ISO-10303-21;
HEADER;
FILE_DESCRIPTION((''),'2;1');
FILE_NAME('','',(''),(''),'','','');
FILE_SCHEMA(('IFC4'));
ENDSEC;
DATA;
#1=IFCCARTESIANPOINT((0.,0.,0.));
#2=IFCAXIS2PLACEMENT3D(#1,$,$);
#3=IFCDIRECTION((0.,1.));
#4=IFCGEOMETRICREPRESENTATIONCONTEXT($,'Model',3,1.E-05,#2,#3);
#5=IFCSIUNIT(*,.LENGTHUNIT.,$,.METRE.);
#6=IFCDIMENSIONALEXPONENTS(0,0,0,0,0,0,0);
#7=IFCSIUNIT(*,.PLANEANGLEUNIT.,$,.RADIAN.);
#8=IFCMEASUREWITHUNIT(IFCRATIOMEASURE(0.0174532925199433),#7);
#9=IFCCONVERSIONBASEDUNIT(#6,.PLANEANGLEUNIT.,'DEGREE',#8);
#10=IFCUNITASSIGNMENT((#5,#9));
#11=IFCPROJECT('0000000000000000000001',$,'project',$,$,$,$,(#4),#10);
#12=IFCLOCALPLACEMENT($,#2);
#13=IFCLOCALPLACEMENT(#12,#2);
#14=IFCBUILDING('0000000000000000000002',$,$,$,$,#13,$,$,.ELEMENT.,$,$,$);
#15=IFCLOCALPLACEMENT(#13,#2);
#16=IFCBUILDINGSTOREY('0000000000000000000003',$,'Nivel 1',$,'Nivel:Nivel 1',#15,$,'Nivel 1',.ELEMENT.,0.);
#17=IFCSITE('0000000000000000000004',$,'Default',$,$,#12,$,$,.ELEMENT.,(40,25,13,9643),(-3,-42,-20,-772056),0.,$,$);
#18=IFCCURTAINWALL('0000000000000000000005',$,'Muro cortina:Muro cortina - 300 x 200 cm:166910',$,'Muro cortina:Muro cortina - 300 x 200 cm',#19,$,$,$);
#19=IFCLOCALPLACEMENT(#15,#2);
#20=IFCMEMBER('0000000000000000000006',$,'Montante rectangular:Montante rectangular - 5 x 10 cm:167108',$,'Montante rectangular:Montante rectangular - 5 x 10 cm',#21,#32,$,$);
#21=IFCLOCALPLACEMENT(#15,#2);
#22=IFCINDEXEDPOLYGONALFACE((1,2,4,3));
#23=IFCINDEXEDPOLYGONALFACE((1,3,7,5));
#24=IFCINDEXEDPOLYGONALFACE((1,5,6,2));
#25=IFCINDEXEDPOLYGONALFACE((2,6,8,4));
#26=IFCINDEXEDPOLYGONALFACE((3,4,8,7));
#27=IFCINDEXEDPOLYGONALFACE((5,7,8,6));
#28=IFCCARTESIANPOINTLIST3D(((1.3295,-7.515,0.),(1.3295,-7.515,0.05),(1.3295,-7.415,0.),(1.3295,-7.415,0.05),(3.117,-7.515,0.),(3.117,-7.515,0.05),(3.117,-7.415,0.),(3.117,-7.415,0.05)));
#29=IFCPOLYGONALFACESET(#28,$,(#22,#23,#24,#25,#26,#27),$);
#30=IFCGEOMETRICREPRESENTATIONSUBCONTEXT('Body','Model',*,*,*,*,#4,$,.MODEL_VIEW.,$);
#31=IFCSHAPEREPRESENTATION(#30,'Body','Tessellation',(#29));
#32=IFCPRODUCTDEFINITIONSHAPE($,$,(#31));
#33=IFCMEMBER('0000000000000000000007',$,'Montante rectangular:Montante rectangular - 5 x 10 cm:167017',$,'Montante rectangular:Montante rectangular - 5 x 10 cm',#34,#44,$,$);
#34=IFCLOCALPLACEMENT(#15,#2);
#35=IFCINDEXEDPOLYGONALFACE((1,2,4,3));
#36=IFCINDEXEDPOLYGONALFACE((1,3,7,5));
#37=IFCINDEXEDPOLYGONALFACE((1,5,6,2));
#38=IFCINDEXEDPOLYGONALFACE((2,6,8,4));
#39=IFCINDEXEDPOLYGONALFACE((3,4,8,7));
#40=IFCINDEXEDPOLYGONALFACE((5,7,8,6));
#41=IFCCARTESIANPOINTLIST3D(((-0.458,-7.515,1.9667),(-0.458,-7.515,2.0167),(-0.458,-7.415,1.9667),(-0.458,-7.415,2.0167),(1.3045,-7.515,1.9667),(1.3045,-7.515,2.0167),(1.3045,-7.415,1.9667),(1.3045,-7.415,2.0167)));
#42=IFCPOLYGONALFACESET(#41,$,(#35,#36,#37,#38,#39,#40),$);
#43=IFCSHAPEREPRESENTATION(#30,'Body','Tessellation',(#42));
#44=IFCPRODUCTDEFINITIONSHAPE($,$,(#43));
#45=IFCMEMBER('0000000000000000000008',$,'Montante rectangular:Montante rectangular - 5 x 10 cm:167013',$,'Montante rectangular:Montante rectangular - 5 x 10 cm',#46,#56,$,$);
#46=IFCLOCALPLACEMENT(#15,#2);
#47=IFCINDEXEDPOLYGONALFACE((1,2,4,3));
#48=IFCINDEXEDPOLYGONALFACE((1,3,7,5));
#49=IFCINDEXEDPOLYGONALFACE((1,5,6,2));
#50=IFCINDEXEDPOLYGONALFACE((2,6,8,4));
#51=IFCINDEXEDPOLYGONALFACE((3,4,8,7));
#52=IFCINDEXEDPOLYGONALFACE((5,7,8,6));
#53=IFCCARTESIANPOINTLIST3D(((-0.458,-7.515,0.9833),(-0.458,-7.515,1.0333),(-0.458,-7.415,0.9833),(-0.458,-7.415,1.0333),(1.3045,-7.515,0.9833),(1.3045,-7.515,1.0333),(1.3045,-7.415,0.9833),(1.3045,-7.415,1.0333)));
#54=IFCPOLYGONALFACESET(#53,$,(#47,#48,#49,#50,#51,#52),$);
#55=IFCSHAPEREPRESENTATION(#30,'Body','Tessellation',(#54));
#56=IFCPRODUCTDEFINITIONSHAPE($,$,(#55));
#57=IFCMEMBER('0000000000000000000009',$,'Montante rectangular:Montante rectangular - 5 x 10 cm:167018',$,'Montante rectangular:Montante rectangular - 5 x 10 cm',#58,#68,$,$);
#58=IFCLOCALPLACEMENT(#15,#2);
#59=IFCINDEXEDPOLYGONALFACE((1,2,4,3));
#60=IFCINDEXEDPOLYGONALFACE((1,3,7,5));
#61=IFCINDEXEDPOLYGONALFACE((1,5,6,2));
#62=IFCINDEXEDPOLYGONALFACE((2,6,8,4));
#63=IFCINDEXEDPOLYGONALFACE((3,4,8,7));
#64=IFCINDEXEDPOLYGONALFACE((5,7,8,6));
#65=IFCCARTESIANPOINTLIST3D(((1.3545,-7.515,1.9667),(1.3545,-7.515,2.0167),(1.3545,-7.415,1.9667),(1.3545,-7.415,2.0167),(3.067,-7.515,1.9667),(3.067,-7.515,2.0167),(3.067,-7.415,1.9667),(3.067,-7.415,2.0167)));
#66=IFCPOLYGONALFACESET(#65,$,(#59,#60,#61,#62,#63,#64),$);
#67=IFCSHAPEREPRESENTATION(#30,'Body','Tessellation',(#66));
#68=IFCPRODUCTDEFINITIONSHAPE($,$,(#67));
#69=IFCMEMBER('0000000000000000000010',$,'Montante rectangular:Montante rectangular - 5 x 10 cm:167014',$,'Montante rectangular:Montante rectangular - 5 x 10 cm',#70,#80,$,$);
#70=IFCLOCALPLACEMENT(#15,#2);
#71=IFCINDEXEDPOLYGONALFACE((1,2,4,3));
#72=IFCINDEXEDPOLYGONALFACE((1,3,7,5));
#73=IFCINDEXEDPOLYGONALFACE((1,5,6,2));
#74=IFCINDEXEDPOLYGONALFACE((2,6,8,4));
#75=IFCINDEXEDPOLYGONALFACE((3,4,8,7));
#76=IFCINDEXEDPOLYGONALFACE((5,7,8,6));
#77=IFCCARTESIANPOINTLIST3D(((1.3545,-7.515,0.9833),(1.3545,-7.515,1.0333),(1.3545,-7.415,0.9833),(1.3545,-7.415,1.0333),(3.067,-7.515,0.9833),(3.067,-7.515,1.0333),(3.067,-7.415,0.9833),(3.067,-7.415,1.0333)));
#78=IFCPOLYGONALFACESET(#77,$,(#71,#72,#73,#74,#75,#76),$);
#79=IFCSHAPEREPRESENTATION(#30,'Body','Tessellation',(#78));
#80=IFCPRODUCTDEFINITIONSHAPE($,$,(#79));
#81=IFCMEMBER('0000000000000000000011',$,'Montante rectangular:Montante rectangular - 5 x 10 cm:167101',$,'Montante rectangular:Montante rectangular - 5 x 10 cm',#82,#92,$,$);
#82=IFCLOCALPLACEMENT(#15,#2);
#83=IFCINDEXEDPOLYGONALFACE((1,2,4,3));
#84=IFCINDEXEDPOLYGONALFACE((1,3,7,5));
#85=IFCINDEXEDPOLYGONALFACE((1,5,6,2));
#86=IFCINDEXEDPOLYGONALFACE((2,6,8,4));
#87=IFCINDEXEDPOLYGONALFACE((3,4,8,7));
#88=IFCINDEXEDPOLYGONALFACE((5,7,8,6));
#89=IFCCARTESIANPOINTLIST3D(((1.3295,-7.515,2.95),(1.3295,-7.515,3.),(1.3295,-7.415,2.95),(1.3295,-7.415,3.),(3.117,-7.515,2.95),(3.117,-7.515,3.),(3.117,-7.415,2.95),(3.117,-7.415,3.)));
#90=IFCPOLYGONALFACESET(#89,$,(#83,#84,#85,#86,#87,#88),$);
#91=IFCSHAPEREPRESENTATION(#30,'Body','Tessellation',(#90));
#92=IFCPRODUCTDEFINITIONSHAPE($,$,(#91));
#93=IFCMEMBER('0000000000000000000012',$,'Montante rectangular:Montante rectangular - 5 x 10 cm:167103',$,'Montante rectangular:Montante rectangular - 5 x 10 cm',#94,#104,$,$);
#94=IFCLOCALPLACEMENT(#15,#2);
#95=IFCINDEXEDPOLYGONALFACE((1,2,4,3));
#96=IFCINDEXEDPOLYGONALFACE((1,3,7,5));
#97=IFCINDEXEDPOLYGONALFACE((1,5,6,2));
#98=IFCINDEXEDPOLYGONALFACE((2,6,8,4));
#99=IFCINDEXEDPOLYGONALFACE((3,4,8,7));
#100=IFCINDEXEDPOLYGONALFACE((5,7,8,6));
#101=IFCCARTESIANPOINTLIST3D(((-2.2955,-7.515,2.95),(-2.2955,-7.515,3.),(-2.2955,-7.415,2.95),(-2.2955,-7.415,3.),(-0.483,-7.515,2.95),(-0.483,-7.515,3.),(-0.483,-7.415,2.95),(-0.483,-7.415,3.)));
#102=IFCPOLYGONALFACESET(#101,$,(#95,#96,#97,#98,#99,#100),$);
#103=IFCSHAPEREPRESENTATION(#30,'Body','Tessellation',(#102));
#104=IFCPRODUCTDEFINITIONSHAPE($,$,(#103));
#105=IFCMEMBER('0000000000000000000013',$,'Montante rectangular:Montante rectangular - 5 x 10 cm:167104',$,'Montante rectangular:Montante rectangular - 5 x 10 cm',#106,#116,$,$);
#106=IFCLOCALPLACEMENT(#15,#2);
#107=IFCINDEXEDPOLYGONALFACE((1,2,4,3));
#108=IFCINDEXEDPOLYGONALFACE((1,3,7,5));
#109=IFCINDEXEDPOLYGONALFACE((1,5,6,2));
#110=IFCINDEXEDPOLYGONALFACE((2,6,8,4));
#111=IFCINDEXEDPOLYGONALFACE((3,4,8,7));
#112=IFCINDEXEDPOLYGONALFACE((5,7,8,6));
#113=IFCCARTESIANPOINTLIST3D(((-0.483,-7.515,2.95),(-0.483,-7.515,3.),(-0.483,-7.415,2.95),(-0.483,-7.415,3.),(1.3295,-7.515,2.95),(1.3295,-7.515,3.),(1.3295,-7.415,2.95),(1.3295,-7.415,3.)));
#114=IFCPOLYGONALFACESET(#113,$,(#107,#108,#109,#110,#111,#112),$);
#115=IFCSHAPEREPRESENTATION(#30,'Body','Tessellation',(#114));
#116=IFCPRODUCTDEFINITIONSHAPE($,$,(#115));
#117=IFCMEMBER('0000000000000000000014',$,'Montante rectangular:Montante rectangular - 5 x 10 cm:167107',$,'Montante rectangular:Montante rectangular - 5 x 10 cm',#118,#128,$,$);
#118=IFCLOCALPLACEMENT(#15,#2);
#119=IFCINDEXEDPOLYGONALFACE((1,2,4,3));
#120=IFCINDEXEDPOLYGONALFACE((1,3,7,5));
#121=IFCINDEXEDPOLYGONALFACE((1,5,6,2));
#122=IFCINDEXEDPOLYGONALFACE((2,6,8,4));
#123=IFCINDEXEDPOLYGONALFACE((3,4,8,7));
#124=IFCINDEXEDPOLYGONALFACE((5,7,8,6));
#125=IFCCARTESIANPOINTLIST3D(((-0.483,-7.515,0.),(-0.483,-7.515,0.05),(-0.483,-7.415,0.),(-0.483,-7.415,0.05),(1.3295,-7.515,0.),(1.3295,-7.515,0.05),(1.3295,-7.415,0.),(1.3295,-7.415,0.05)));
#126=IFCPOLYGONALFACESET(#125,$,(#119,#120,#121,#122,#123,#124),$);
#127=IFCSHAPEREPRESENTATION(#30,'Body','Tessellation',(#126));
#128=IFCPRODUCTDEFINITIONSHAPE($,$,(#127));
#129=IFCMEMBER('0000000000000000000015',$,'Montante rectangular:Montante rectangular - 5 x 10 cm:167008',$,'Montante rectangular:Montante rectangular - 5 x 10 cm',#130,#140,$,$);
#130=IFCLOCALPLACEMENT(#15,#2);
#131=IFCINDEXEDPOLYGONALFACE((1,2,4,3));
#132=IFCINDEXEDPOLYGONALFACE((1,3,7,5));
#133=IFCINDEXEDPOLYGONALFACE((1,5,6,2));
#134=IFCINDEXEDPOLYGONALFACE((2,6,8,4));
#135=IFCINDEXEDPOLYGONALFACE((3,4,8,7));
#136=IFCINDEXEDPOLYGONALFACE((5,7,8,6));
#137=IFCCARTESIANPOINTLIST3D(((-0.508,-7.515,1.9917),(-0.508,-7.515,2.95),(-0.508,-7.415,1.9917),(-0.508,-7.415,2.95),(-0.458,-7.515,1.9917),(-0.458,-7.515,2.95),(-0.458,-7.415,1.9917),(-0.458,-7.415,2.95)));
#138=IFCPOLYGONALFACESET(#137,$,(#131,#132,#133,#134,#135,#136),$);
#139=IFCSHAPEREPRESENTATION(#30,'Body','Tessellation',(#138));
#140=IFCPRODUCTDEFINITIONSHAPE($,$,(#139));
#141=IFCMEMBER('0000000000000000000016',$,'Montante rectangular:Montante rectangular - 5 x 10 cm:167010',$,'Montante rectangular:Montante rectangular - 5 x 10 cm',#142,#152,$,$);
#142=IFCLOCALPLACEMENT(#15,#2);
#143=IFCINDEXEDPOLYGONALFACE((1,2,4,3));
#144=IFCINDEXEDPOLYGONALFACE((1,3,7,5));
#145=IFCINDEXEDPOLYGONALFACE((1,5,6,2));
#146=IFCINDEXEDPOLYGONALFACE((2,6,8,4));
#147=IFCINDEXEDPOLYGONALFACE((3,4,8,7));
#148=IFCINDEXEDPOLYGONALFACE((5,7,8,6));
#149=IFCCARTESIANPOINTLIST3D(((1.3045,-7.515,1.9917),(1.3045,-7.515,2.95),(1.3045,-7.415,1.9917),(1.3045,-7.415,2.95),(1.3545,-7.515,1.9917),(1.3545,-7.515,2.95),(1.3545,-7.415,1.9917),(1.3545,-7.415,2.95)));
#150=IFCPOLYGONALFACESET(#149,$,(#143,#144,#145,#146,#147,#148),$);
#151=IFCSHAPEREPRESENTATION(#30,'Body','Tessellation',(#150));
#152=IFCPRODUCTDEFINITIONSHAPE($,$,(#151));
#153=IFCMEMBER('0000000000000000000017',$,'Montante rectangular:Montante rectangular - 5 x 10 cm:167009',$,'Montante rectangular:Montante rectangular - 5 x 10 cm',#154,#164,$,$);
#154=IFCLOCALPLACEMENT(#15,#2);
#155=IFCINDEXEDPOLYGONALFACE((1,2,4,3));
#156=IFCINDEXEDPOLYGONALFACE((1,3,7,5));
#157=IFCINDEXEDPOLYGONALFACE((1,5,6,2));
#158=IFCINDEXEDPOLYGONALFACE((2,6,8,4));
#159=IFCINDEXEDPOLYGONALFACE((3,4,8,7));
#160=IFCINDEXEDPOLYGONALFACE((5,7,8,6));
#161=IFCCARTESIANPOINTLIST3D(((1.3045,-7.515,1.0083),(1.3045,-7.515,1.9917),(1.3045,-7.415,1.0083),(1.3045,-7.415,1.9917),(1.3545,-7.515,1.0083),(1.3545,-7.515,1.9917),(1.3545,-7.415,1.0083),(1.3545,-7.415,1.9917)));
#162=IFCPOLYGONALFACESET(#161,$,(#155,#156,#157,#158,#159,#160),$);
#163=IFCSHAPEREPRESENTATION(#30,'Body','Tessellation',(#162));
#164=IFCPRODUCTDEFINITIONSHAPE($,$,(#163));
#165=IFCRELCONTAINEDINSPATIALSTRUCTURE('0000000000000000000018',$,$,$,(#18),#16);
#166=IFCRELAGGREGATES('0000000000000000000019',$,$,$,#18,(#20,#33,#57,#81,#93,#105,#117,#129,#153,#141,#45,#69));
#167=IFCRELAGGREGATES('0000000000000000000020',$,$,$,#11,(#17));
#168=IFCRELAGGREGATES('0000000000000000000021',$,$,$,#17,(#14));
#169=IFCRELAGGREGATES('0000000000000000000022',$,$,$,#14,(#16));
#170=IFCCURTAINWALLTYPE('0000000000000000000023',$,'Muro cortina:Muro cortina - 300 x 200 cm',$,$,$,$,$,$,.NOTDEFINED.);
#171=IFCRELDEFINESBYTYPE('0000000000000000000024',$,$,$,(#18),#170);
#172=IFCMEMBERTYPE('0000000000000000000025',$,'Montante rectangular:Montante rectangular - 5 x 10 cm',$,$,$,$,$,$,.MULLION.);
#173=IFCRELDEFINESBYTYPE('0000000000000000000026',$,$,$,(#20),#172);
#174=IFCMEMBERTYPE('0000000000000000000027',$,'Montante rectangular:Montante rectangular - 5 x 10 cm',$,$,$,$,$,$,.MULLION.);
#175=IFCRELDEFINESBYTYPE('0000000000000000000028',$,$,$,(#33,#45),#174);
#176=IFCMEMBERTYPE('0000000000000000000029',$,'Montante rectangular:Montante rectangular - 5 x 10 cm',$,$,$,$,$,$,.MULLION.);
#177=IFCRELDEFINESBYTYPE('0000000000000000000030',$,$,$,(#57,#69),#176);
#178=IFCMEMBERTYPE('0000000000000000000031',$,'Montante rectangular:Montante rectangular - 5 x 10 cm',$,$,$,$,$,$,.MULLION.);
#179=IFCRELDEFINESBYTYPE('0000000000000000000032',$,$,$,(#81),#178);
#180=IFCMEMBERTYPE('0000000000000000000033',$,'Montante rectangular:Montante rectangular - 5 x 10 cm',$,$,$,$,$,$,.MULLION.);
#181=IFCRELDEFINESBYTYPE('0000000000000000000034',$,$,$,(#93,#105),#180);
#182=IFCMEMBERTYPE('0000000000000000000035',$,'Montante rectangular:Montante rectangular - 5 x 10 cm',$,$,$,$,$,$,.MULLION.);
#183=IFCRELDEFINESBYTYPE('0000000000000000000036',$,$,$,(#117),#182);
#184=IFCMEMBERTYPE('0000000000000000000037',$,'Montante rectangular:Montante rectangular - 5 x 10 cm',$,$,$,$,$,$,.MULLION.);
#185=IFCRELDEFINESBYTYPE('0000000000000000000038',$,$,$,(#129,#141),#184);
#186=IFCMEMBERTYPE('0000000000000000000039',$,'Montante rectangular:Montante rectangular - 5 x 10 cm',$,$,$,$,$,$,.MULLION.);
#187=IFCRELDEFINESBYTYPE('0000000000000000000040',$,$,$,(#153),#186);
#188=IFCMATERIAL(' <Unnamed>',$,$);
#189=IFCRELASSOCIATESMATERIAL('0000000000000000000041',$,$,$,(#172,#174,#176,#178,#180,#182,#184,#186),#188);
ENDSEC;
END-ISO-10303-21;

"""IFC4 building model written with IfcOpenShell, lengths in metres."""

from ifc_helpers import new_model, entity, si_unit, converted_unit, direction, frame, origin, origin_2d_with_axis, place, context, subcontext, project, spatial, rectangle, extrude, source, transform, mapped, material, type_object, type_shapes, element, aggregate, save


model = new_model("IFC4")

# Units and contexts
model_context = context("Model", 3, precision=1e-05, world=origin(), true_north=direction((0.0, 1.0)))
body_context = subcontext(model_context, "Body", "Model", "MODEL_VIEW")
ifc_project = project(units=[si_unit("LENGTHUNIT", "METRE"), converted_unit("PLANEANGLEUNIT", "DEGREE", entity("IfcRatioMeasure", 0.0174532925199433), si_unit("PLANEANGLEUNIT", "RADIAN"), dimensions=[0, 0, 0, 0, 0, 0, 0])], contexts=[model_context])

# Site, building, storey
site_placement = place(None, origin())
site = spatial("IfcSite", under=ifc_project, at=site_placement, Name="Default", CompositionType="ELEMENT", RefLatitude=(40, 25, 13, 9643), RefLongitude=(-3, -42, -20, -772056), RefElevation=0.0)
building_placement = place(site_placement, origin())
building = spatial("IfcBuilding", under=site, at=building_placement, CompositionType="ELEMENT")
storey_placement = place(building_placement, origin())
storey = spatial("IfcBuildingStorey", under=building, at=storey_placement, Name="Nivel 1", ObjectType="Nivel:Nivel 1", LongName="Nivel 1", CompositionType="ELEMENT", Elevation=0.0)

# Curtain wall, members
curtain_wall_type = type_object("IfcCurtainWallType", Name="Muro cortina:Muro cortina - 300 x 200 cm", PredefinedType="NOTDEFINED")
curtain_wall_placement = place(storey_placement, origin())
curtain_wall = element("IfcCurtainWall", 1, at=curtain_wall_placement, inside=storey, type_object=curtain_wall_type, Name="Muro cortina:Muro cortina - 300 x 200 cm:166910", ObjectType="Muro cortina:Muro cortina - 300 x 200 cm")
ifc_material_1 = material(Name=" <Unnamed>")
member_type_1 = type_object("IfcMemberType", Name="Montante rectangular:Montante rectangular - 5 x 10 cm", PredefinedType="MULLION", material=ifc_material_1)
shared_shape_1 = source(origin(), body_context, "Body", "SweptSolid", [
    extrude(rectangle(XDim=0.1, YDim=0.05, at=origin_2d_with_axis()), frame((-0.025, 0.0, -1.7875), z_axis=(0.0, 0.0, 1.0), x_axis=(0.0, -1.0, 0.0)), (0.0, 0.0, 1.0), 1.7875),
])
type_shapes(member_type_1, [shared_shape_1])
member_1_placement = place(storey_placement, frame((1.3295, -7.465, 0.0), z_axis=(-1.0, 0.0, 0.0), x_axis=(0.0, 0.0, -1.0)))
member_1 = element("IfcMember", 2, at=member_1_placement, type_object=member_type_1, Name="Montante rectangular:Montante rectangular - 5 x 10 cm:167108", ObjectType="Montante rectangular:Montante rectangular - 5 x 10 cm", context=body_context, shape_type="MappedRepresentation", body=[
    mapped(shared_shape_1, transform((0.0, 0.0, 0.0), scale=1.0)),
])
member_type_2 = type_object("IfcMemberType", Name="Montante rectangular:Montante rectangular - 5 x 10 cm", PredefinedType="MULLION", material=ifc_material_1)
shared_shape_2 = source(origin(), body_context, "Body", "SweptSolid", [
    extrude(rectangle(XDim=0.1, YDim=0.05, at=origin_2d_with_axis()), frame((0.0, 0.0, -1.7625), z_axis=(0.0, 0.0, 1.0), x_axis=(0.0, -1.0, 0.0)), (0.0, 0.0, 1.0), 1.7625),
])
type_shapes(member_type_2, [shared_shape_2])
member_2_placement = place(storey_placement, frame((1.3045, -7.465, 1.9917), z_axis=(1.0, 0.0, 0.0), x_axis=(0.0, 0.0, 1.0)))
member_2 = element("IfcMember", 3, at=member_2_placement, type_object=member_type_2, Name="Montante rectangular:Montante rectangular - 5 x 10 cm:167017", ObjectType="Montante rectangular:Montante rectangular - 5 x 10 cm", context=body_context, shape_type="MappedRepresentation", body=[
    mapped(shared_shape_2, transform((0.0, 0.0, 0.0), scale=1.0)),
])
member_3_placement = place(storey_placement, frame((1.3045, -7.465, 1.0083), z_axis=(1.0, 0.0, 0.0), x_axis=(0.0, 0.0, 1.0)))
member_3 = element("IfcMember", 4, at=member_3_placement, type_object=member_type_2, Name="Montante rectangular:Montante rectangular - 5 x 10 cm:167013", ObjectType="Montante rectangular:Montante rectangular - 5 x 10 cm", context=body_context, shape_type="MappedRepresentation", body=[
    mapped(shared_shape_2, transform((0.0, 0.0, 0.0), scale=1.0)),
])
member_type_3 = type_object("IfcMemberType", Name="Montante rectangular:Montante rectangular - 5 x 10 cm", PredefinedType="MULLION", material=ifc_material_1)
shared_shape_3 = source(origin(), body_context, "Body", "SweptSolid", [
    extrude(rectangle(XDim=0.1, YDim=0.05, at=origin_2d_with_axis()), frame((0.0, 0.0, -1.7125), z_axis=(0.0, 0.0, 1.0), x_axis=(0.0, -1.0, 0.0)), (0.0, 0.0, 1.0), 1.7125),
])
type_shapes(member_type_3, [shared_shape_3])
member_4_placement = place(storey_placement, frame((3.067, -7.465, 1.9917), z_axis=(1.0, 0.0, 0.0), x_axis=(0.0, 0.0, 1.0)))
member_4 = element("IfcMember", 5, at=member_4_placement, type_object=member_type_3, Name="Montante rectangular:Montante rectangular - 5 x 10 cm:167018", ObjectType="Montante rectangular:Montante rectangular - 5 x 10 cm", context=body_context, shape_type="MappedRepresentation", body=[
    mapped(shared_shape_3, transform((0.0, 0.0, 0.0), scale=1.0)),
])
member_5_placement = place(storey_placement, frame((3.067, -7.465, 1.0083), z_axis=(1.0, 0.0, 0.0), x_axis=(0.0, 0.0, 1.0)))
member_5 = element("IfcMember", 6, at=member_5_placement, type_object=member_type_3, Name="Montante rectangular:Montante rectangular - 5 x 10 cm:167014", ObjectType="Montante rectangular:Montante rectangular - 5 x 10 cm", context=body_context, shape_type="MappedRepresentation", body=[
    mapped(shared_shape_3, transform((0.0, 0.0, 0.0), scale=1.0)),
])
member_type_4 = type_object("IfcMemberType", Name="Montante rectangular:Montante rectangular - 5 x 10 cm", PredefinedType="MULLION", material=ifc_material_1)
shared_shape_4 = source(origin(), body_context, "Body", "SweptSolid", [
    extrude(rectangle(XDim=0.1, YDim=0.05, at=origin_2d_with_axis()), frame((-0.025, 0.0, -1.7875), z_axis=(0.0, 0.0, 1.0), x_axis=(0.0, -1.0, 0.0)), (0.0, 0.0, 1.0), 1.7875),
])
type_shapes(member_type_4, [shared_shape_4])
member_6_placement = place(storey_placement, frame((3.117, -7.465, 3.0), z_axis=(1.0, 0.0, 0.0), x_axis=(0.0, 0.0, 1.0)))
member_6 = element("IfcMember", 7, at=member_6_placement, type_object=member_type_4, Name="Montante rectangular:Montante rectangular - 5 x 10 cm:167101", ObjectType="Montante rectangular:Montante rectangular - 5 x 10 cm", context=body_context, shape_type="MappedRepresentation", body=[
    mapped(shared_shape_4, transform((0.0, 0.0, 0.0), scale=1.0)),
])
member_type_5 = type_object("IfcMemberType", Name="Montante rectangular:Montante rectangular - 5 x 10 cm", PredefinedType="MULLION", material=ifc_material_1)
shared_shape_5 = source(origin(), body_context, "Body", "SweptSolid", [
    extrude(rectangle(XDim=0.1, YDim=0.05, at=origin_2d_with_axis()), frame((-0.025, 0.0, -1.8125), z_axis=(0.0, 0.0, 1.0), x_axis=(0.0, -1.0, 0.0)), (0.0, 0.0, 1.0), 1.8125),
])
type_shapes(member_type_5, [shared_shape_5])
member_7_placement = place(storey_placement, frame((-0.483, -7.465, 3.0), z_axis=(1.0, 0.0, 0.0), x_axis=(0.0, 0.0, 1.0)))
member_7 = element("IfcMember", 8, at=member_7_placement, type_object=member_type_5, Name="Montante rectangular:Montante rectangular - 5 x 10 cm:167103", ObjectType="Montante rectangular:Montante rectangular - 5 x 10 cm", context=body_context, shape_type="MappedRepresentation", body=[
    mapped(shared_shape_5, transform((0.0, 0.0, 0.0), scale=1.0)),
])
member_8_placement = place(storey_placement, frame((1.3295, -7.465, 3.0), z_axis=(1.0, 0.0, 0.0), x_axis=(0.0, 0.0, 1.0)))
member_8 = element("IfcMember", 9, at=member_8_placement, type_object=member_type_5, Name="Montante rectangular:Montante rectangular - 5 x 10 cm:167104", ObjectType="Montante rectangular:Montante rectangular - 5 x 10 cm", context=body_context, shape_type="MappedRepresentation", body=[
    mapped(shared_shape_5, transform((0.0, 0.0, 0.0), scale=1.0)),
])
member_type_6 = type_object("IfcMemberType", Name="Montante rectangular:Montante rectangular - 5 x 10 cm", PredefinedType="MULLION", material=ifc_material_1)
shared_shape_6 = source(origin(), body_context, "Body", "SweptSolid", [
    extrude(rectangle(XDim=0.1, YDim=0.05, at=origin_2d_with_axis()), frame((-0.025, 0.0, -1.8125), z_axis=(0.0, 0.0, 1.0), x_axis=(0.0, -1.0, 0.0)), (0.0, 0.0, 1.0), 1.8125),
])
type_shapes(member_type_6, [shared_shape_6])
member_9_placement = place(storey_placement, frame((-0.483, -7.465, 0.0), z_axis=(-1.0, 0.0, 0.0), x_axis=(0.0, 0.0, -1.0)))
member_9 = element("IfcMember", 10, at=member_9_placement, type_object=member_type_6, Name="Montante rectangular:Montante rectangular - 5 x 10 cm:167107", ObjectType="Montante rectangular:Montante rectangular - 5 x 10 cm", context=body_context, shape_type="MappedRepresentation", body=[
    mapped(shared_shape_6, transform((0.0, 0.0, 0.0), scale=1.0)),
])
member_type_7 = type_object("IfcMemberType", Name="Montante rectangular:Montante rectangular - 5 x 10 cm", PredefinedType="MULLION", material=ifc_material_1)
shared_shape_7 = source(origin(), body_context, "Body", "SweptSolid", [
    extrude(rectangle(XDim=0.1, YDim=0.05, at=origin_2d_with_axis()), frame((0.0, 0.0, -0.9583), z_axis=(0.0, 0.0, 1.0), x_axis=(0.0, -1.0, 0.0)), (0.0, 0.0, 1.0), 0.9583),
])
type_shapes(member_type_7, [shared_shape_7])
member_10_placement = place(storey_placement, frame((-0.483, -7.465, 1.9917), z_axis=(0.0, 0.0, -1.0), x_axis=(1.0, 0.0, 0.0)))
member_10 = element("IfcMember", 11, at=member_10_placement, type_object=member_type_7, Name="Montante rectangular:Montante rectangular - 5 x 10 cm:167008", ObjectType="Montante rectangular:Montante rectangular - 5 x 10 cm", context=body_context, shape_type="MappedRepresentation", body=[
    mapped(shared_shape_7, transform((0.0, 0.0, 0.0), scale=1.0)),
])
member_11_placement = place(storey_placement, frame((1.3295, -7.465, 1.9917), z_axis=(0.0, 0.0, -1.0), x_axis=(1.0, 0.0, 0.0)))
member_11 = element("IfcMember", 12, at=member_11_placement, type_object=member_type_7, Name="Montante rectangular:Montante rectangular - 5 x 10 cm:167010", ObjectType="Montante rectangular:Montante rectangular - 5 x 10 cm", context=body_context, shape_type="MappedRepresentation", body=[
    mapped(shared_shape_7, transform((0.0, 0.0, 0.0), scale=1.0)),
])
member_type_8 = type_object("IfcMemberType", Name="Montante rectangular:Montante rectangular - 5 x 10 cm", PredefinedType="MULLION", material=ifc_material_1)
shared_shape_8 = source(origin(), body_context, "Body", "SweptSolid", [
    extrude(rectangle(XDim=0.1, YDim=0.05, at=origin_2d_with_axis()), frame((0.0, 0.0, -0.9833), z_axis=(0.0, 0.0, 1.0), x_axis=(0.0, -1.0, 0.0)), (0.0, 0.0, 1.0), 0.9833),
])
type_shapes(member_type_8, [shared_shape_8])
member_12_placement = place(storey_placement, frame((1.3295, -7.465, 1.0083), z_axis=(0.0, 0.0, -1.0), x_axis=(1.0, 0.0, 0.0)))
member_12 = element("IfcMember", 13, at=member_12_placement, type_object=member_type_8, Name="Montante rectangular:Montante rectangular - 5 x 10 cm:167009", ObjectType="Montante rectangular:Montante rectangular - 5 x 10 cm", context=body_context, shape_type="MappedRepresentation", body=[
    mapped(shared_shape_8, transform((0.0, 0.0, 0.0), scale=1.0)),
])
aggregate(curtain_wall, [member_1, member_2, member_4, member_6, member_7, member_8, member_9, member_10, member_12, member_11, member_3, member_5])

save(model, "model.ifc")
